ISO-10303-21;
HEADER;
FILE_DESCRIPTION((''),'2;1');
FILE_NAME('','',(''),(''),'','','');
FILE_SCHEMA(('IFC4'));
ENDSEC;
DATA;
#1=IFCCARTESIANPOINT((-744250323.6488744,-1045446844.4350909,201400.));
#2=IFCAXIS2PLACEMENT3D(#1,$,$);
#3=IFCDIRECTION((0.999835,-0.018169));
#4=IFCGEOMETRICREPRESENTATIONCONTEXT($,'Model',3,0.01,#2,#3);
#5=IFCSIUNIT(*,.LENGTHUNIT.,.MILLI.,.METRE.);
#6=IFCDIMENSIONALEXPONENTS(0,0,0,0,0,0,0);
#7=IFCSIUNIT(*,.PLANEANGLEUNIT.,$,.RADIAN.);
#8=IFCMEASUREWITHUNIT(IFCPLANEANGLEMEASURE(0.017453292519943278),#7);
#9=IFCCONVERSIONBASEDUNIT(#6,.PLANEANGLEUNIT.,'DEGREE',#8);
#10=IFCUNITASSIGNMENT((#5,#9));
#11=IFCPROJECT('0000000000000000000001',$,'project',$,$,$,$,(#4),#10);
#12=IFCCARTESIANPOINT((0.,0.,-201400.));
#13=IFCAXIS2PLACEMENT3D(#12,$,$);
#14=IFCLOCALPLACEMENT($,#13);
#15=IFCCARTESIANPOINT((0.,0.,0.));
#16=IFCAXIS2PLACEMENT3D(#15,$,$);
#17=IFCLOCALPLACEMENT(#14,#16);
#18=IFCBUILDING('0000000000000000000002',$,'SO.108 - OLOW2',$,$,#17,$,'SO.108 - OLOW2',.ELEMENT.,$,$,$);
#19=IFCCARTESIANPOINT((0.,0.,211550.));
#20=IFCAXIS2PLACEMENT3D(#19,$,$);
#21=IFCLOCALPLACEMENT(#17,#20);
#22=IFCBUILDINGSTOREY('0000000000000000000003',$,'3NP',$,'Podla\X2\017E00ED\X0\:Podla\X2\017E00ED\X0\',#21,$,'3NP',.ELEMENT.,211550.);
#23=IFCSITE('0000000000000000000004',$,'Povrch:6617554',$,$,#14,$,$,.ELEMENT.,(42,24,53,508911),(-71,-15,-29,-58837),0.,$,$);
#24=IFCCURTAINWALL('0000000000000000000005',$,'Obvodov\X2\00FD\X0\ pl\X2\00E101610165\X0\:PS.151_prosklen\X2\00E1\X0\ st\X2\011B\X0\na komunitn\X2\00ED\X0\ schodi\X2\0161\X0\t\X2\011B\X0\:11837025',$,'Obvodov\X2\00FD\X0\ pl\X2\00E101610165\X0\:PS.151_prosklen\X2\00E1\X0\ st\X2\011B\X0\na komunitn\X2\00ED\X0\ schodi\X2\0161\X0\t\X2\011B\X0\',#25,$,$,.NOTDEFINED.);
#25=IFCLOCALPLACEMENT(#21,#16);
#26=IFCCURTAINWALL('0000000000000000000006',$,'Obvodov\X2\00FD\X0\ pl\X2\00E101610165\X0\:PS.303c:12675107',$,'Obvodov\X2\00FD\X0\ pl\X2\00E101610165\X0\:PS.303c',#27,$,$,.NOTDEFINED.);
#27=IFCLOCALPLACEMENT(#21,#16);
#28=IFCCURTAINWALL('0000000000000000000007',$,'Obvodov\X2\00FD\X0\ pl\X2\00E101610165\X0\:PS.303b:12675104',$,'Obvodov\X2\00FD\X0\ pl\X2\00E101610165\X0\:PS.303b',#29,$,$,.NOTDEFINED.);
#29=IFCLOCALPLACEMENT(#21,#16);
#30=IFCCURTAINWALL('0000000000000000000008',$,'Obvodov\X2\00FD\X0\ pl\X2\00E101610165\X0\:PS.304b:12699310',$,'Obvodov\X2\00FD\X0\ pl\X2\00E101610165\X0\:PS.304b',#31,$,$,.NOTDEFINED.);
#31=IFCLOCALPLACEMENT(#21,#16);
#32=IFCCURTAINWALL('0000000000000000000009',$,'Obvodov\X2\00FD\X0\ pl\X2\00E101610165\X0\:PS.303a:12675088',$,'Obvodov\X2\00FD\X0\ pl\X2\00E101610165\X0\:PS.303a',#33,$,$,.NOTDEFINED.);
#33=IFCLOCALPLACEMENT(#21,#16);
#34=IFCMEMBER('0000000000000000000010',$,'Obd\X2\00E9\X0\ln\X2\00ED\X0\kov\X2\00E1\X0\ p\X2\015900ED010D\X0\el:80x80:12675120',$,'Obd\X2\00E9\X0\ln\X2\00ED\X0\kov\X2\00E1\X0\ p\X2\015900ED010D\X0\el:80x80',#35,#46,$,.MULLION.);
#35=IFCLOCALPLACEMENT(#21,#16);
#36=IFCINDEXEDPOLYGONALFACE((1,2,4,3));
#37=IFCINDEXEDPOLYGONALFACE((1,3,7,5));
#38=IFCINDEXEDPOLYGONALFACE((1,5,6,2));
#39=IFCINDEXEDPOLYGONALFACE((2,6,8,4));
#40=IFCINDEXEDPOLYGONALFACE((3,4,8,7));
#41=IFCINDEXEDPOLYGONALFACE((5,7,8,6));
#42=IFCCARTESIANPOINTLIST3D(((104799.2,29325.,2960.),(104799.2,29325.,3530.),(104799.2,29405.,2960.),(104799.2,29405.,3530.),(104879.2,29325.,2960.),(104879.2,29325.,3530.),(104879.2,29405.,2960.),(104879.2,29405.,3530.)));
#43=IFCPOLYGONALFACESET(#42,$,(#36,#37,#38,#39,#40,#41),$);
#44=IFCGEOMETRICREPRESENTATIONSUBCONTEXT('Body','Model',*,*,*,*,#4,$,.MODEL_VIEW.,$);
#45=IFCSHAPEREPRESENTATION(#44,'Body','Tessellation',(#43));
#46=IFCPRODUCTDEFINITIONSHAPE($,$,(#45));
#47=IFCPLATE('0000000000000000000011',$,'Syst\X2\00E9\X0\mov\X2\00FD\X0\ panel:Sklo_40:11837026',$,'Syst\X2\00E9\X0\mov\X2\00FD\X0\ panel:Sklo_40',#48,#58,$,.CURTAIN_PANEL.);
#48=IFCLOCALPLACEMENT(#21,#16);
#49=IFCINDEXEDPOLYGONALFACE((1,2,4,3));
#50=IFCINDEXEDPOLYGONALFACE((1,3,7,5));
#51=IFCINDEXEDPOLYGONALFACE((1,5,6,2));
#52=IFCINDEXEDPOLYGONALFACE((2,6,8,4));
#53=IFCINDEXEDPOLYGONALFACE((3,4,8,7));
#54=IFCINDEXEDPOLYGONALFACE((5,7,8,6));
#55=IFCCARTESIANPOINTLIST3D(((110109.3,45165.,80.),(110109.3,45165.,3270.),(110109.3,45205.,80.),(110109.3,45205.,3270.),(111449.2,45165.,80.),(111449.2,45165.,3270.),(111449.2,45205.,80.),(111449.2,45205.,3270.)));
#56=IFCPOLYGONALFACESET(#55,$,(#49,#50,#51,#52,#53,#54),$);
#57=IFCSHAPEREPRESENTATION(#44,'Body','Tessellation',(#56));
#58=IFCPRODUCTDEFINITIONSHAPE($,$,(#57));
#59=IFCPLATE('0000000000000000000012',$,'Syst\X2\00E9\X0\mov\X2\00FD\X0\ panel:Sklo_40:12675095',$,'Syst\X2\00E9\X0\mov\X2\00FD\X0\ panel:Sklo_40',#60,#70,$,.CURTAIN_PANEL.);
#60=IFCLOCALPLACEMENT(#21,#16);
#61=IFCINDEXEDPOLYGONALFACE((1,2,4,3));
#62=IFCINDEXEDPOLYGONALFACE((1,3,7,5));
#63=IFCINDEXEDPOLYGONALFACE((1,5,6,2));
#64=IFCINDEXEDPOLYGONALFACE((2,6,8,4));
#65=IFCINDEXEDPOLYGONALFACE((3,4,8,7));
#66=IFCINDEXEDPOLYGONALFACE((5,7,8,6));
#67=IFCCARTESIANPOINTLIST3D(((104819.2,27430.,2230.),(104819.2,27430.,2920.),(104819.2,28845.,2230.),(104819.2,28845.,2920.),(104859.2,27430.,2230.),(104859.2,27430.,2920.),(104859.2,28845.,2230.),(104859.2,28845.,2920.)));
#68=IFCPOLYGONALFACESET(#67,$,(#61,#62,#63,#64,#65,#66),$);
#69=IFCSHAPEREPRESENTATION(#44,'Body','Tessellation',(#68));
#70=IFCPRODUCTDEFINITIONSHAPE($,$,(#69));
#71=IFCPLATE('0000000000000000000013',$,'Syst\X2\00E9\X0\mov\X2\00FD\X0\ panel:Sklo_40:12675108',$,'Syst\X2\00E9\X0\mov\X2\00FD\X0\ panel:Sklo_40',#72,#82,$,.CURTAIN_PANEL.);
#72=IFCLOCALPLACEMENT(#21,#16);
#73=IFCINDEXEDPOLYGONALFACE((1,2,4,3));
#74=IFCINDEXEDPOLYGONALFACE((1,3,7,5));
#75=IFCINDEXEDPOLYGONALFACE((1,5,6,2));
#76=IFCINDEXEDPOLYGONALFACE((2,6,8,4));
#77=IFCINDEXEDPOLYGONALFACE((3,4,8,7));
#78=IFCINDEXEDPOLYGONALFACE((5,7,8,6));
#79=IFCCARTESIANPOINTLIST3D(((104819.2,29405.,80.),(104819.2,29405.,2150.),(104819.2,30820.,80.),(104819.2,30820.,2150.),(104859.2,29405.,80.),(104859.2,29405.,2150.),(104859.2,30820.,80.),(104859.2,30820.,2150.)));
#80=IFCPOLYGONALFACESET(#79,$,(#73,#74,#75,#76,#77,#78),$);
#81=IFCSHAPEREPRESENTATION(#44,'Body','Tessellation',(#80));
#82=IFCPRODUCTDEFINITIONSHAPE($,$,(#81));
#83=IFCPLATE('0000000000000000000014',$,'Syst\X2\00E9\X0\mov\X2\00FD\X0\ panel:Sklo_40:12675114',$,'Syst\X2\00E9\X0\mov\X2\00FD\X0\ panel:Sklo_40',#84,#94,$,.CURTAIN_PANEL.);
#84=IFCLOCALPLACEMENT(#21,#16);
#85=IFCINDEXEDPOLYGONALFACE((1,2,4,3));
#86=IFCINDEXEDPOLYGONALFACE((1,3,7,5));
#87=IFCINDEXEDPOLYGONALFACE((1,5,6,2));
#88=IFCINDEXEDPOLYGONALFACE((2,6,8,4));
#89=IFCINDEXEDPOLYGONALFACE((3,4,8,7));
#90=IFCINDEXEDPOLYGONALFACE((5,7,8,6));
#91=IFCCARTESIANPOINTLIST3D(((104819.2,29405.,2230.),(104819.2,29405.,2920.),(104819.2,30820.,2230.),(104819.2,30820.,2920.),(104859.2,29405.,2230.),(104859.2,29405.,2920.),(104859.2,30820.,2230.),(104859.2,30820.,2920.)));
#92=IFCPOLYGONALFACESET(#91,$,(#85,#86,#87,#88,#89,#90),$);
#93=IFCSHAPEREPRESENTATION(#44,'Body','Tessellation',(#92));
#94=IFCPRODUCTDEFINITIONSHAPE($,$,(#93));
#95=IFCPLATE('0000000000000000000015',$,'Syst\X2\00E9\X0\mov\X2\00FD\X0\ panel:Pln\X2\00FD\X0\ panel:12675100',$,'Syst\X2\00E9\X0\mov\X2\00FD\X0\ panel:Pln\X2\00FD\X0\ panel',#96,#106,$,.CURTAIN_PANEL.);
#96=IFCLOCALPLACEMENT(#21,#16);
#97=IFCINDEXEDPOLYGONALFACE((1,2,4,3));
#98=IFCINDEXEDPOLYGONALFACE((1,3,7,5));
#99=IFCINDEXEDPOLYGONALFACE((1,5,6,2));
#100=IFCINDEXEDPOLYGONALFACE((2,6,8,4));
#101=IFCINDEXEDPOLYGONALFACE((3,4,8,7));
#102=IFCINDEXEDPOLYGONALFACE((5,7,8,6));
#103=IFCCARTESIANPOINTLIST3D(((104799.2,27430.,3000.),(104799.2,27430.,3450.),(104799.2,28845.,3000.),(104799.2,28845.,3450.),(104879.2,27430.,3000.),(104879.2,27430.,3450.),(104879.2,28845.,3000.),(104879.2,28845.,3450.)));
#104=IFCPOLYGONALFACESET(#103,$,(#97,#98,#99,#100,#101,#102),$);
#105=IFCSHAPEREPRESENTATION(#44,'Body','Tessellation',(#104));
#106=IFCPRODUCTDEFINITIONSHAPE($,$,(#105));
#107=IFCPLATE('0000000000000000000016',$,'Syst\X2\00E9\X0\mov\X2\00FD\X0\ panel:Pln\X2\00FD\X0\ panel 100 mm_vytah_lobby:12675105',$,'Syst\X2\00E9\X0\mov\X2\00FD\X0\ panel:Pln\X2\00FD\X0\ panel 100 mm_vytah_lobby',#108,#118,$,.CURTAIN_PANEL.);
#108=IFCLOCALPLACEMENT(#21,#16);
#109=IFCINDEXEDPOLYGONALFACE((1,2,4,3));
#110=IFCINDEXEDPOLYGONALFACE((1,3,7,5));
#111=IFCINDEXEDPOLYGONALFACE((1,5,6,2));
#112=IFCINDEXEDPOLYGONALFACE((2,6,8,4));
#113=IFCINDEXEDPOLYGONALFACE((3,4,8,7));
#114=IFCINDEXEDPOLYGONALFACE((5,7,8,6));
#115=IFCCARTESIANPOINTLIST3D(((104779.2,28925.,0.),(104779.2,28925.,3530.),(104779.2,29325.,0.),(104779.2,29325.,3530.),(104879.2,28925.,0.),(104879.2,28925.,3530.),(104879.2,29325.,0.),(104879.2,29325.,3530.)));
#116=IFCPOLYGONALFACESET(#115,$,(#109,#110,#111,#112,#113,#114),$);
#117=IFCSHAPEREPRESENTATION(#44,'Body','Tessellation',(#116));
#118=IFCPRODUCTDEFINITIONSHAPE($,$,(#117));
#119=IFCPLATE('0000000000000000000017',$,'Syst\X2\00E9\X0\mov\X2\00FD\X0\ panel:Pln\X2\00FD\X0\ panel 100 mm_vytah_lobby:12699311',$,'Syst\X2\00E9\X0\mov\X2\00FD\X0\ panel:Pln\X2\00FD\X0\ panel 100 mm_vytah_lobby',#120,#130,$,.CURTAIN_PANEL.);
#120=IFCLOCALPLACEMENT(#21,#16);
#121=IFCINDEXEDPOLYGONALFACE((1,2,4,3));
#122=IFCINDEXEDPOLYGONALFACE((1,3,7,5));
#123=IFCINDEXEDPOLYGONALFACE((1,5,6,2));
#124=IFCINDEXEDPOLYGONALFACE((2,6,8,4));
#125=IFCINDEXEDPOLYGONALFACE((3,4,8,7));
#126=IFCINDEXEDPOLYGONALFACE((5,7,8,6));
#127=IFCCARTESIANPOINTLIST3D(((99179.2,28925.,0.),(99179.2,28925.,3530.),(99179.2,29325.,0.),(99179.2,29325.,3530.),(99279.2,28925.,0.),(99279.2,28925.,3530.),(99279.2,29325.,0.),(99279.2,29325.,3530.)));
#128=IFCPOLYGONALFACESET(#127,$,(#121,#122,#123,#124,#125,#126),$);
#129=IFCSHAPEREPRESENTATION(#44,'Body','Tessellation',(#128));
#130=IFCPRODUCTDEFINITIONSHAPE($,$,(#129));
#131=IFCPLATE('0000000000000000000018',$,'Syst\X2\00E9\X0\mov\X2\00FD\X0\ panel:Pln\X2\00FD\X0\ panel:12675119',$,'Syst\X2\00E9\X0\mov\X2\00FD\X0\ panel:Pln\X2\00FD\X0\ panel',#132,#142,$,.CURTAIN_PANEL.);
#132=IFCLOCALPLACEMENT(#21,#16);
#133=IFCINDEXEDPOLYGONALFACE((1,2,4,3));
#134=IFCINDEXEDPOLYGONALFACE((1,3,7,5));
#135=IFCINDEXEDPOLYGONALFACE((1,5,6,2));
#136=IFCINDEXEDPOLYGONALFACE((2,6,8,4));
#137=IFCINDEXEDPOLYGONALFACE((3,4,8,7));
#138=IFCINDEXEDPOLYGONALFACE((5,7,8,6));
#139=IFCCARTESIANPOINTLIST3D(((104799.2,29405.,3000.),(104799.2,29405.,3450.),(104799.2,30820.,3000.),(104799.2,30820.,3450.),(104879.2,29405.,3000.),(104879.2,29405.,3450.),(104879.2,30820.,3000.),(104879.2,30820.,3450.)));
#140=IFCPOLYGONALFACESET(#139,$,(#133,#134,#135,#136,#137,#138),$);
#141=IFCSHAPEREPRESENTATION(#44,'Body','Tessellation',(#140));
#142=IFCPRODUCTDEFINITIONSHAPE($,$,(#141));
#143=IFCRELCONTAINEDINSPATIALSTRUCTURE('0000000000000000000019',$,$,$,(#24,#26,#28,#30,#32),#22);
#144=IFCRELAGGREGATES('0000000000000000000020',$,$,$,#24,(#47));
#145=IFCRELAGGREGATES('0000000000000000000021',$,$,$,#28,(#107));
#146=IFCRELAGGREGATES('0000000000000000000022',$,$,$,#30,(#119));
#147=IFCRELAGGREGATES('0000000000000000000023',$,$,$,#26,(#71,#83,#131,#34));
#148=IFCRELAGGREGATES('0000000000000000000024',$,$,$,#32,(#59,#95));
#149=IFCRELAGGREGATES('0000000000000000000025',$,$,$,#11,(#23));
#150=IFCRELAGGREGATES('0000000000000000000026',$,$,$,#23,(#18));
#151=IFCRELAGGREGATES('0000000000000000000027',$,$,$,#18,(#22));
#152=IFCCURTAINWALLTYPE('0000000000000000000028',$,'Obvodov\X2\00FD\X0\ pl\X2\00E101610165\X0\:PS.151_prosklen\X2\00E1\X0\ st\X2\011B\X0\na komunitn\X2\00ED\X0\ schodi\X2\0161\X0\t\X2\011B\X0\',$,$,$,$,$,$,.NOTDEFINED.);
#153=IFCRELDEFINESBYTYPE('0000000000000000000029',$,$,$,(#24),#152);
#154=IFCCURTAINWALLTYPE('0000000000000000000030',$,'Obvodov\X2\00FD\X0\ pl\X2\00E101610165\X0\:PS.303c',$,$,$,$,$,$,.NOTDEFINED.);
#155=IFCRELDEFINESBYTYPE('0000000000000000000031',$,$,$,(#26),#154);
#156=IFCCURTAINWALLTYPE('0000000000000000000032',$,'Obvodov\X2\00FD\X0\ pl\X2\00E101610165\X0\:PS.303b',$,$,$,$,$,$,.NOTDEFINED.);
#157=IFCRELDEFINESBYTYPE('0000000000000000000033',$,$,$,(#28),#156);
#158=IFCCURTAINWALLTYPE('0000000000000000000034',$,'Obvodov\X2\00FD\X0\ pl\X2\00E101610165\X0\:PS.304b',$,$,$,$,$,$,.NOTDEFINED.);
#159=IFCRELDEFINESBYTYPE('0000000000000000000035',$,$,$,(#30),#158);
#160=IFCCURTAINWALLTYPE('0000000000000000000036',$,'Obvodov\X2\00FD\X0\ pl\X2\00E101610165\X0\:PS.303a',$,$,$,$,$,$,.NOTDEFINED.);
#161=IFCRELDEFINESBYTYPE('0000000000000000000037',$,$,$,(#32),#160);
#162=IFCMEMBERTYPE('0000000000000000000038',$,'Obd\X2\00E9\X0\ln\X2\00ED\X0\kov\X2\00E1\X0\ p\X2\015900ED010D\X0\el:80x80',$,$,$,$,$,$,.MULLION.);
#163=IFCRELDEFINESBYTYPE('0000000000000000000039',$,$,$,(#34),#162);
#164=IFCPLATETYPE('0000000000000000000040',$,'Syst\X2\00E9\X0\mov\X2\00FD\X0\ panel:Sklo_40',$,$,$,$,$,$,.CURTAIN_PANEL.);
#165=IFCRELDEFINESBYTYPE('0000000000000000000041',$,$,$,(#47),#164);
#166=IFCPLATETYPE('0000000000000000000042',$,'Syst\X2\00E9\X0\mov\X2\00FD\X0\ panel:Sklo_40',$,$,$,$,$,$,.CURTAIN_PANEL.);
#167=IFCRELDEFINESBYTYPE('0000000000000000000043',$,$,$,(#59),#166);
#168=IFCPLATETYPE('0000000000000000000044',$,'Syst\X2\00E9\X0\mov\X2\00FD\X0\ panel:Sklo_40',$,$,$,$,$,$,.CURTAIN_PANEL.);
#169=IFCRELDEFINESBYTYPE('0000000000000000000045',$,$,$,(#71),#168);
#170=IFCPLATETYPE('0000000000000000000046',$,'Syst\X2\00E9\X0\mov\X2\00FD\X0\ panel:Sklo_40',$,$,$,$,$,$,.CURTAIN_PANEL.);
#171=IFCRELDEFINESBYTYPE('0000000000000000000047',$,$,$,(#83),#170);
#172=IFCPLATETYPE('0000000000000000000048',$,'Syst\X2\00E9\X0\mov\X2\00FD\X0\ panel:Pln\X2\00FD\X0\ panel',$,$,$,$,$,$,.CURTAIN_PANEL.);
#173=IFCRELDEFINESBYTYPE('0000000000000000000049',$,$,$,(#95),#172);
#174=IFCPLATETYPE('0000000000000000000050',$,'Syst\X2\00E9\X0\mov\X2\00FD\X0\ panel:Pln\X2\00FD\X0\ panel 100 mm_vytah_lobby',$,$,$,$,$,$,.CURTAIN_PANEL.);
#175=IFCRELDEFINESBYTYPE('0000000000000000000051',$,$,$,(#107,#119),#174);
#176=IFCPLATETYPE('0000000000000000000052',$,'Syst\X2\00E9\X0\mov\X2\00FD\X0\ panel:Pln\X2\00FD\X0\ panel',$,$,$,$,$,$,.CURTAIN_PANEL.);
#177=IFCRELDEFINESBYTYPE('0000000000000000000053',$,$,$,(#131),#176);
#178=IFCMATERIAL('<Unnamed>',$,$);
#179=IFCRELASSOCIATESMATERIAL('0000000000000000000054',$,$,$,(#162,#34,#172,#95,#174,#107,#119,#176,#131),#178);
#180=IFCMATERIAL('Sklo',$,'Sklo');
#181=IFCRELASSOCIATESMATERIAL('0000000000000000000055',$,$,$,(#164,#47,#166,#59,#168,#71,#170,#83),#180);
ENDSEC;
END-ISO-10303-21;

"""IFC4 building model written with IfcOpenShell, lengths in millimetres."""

from ifc_helpers import new_model, entity, si_unit, converted_unit, direction, frame, origin, place, context, subcontext, project, spatial, indexed_curve, outline, extrude, source, transform, mapped, material, type_object, type_shapes, element, aggregate, save


model = new_model("IFC4")

# Units and contexts
model_context = context("Model", 3, precision=0.01, world=frame((-744250323.6488744, -1045446844.4350909, 201400.0)), true_north=direction((0.999835, -0.018169)))
body_context = subcontext(model_context, "Body", "Model", "MODEL_VIEW")
ifc_project = project(units=[si_unit("LENGTHUNIT", "METRE", prefix="MILLI"), converted_unit("PLANEANGLEUNIT", "DEGREE", entity("IfcPlaneAngleMeasure", 0.017453292519943278), si_unit("PLANEANGLEUNIT", "RADIAN"), dimensions=[0, 0, 0, 0, 0, 0, 0])], contexts=[model_context])

# Site, building, storey
site_placement = place(None, frame((0.0, 0.0, -201400.0)))
site = spatial("IfcSite", under=ifc_project, at=site_placement, Name="Povrch:6617554", CompositionType="ELEMENT", RefLatitude=(42, 24, 53, 508911), RefLongitude=(-71, -15, -29, -58837), RefElevation=0.0)
building_placement = place(site_placement, origin())
building = spatial("IfcBuilding", under=site, at=building_placement, Name="SO.108 - OLOW2", LongName="SO.108 - OLOW2", CompositionType="ELEMENT")
storey_placement = place(building_placement, frame((0.0, 0.0, 211550.0)))
storey = spatial("IfcBuildingStorey", under=building, at=storey_placement, Name="3NP", ObjectType="Podlaží:Podlaží", LongName="3NP", CompositionType="ELEMENT", Elevation=211550.0)

# Curtain wall
curtain_wall_type_1 = type_object("IfcCurtainWallType", Name="Obvodový plášť:PS.151_prosklená stěna komunitní schodiště", PredefinedType="NOTDEFINED")
curtain_wall_1_placement = place(storey_placement, frame((0.0, 0.0, -211550.0)))
curtain_wall_1 = element("IfcCurtainWall", 1, at=curtain_wall_1_placement, inside=storey, type_object=curtain_wall_type_1, Name="Obvodový plášť:PS.151_prosklená stěna komunitní schodiště:11837025", ObjectType="Obvodový plášť:PS.151_prosklená stěna komunitní schodiště", PredefinedType="NOTDEFINED")
ifc_material_1 = material(Name="<Unnamed>")

# Curtain wall
curtain_wall_type_2 = type_object("IfcCurtainWallType", Name="Obvodový plášť:PS.303c", PredefinedType="NOTDEFINED")
curtain_wall_2_placement = place(storey_placement, frame((0.0, 0.0, -211550.0)))
curtain_wall_2 = element("IfcCurtainWall", 2, at=curtain_wall_2_placement, inside=storey, type_object=curtain_wall_type_2, Name="Obvodový plášť:PS.303c:12675107", ObjectType="Obvodový plášť:PS.303c", PredefinedType="NOTDEFINED")

# Curtain walls
curtain_wall_type_3 = type_object("IfcCurtainWallType", Name="Obvodový plášť:PS.303b", PredefinedType="NOTDEFINED")
curtain_wall_3_placement = place(storey_placement, frame((0.0, 0.0, -211550.0)))
curtain_wall_3 = element("IfcCurtainWall", 3, at=curtain_wall_3_placement, inside=storey, type_object=curtain_wall_type_3, Name="Obvodový plášť:PS.303b:12675104", ObjectType="Obvodový plášť:PS.303b", PredefinedType="NOTDEFINED")
curtain_wall_type_4 = type_object("IfcCurtainWallType", Name="Obvodový plášť:PS.304b", PredefinedType="NOTDEFINED")
curtain_wall_4_placement = place(storey_placement, frame((0.0, 0.0, -211550.0)))
curtain_wall_4 = element("IfcCurtainWall", 4, at=curtain_wall_4_placement, inside=storey, type_object=curtain_wall_type_4, Name="Obvodový plášť:PS.304b:12699310", ObjectType="Obvodový plášť:PS.304b", PredefinedType="NOTDEFINED")

# Curtain wall
curtain_wall_type_5 = type_object("IfcCurtainWallType", Name="Obvodový plášť:PS.303a", PredefinedType="NOTDEFINED")
curtain_wall_5_placement = place(storey_placement, frame((0.0, 0.0, -211550.0)))
curtain_wall_5 = element("IfcCurtainWall", 5, at=curtain_wall_5_placement, inside=storey, type_object=curtain_wall_type_5, Name="Obvodový plášť:PS.303a:12675088", ObjectType="Obvodový plášť:PS.303a", PredefinedType="NOTDEFINED")

# Member
member_type_1 = type_object("IfcMemberType", Name="Obdélníková příčel:80x80", PredefinedType="MULLION", material=ifc_material_1)
shared_shape_1 = source(origin(), body_context, "Body", "SweptSolid", [
    extrude(outline(indexed_curve([(-40.0, -40.0), (40.0, -40.0), (40.0, 40.0), (-40.0, 40.0), (-40.0, -40.0)], self_intersect=False)), frame((-40.0, 0.0, -570.0), z_axis=(0.0, 0.0, 1.0), x_axis=(-1.0, 0.0, 0.0)), (0.0, 0.0, 1.0), 570.0),
])
type_shapes(member_type_1, [shared_shape_1])
member_1_placement = place(curtain_wall_2_placement, frame((104839.2, 29325.0, 214510.0), z_axis=(0.0, 0.0, -1.0), x_axis=(0.0, -1.0, 0.0)))
member_1 = element("IfcMember", 6, at=member_1_placement, type_object=member_type_1, material=ifc_material_1, Name="Obdélníková příčel:80x80:12675120", ObjectType="Obdélníková příčel:80x80", PredefinedType="MULLION", context=body_context, shape_type="MappedRepresentation", body=[
    mapped(shared_shape_1, transform((0.0, 0.0, 0.0), scale=1.0)),
])

# Plates
ifc_material_2 = material(Name="Sklo", Category="Sklo")
plate_type_1 = type_object("IfcPlateType", Name="Systémový panel:Sklo_40", PredefinedType="CURTAIN_PANEL", material=ifc_material_2)
shared_shape_2 = source(origin(), body_context, "Body", "SweptSolid", [
    extrude(outline(indexed_curve([(-20.0, -670.0), (20.0, -670.0), (20.0, 670.0), (-20.0, 670.0), (-20.0, -670.0)], self_intersect=False)), frame((0.0, 0.0, 0.0), z_axis=(0.0, 0.0, 1.0), x_axis=(0.0, 1.0, 0.0)), (0.0, 0.0, 1.0), 3190.0),
])
type_shapes(plate_type_1, [shared_shape_2])
plate_1_placement = place(curtain_wall_1_placement, frame((110779.3, 45185.0, 211630.0)))
plate_1 = element("IfcPlate", 7, at=plate_1_placement, type_object=plate_type_1, material=ifc_material_2, Name="Systémový panel:Sklo_40:11837026", ObjectType="Systémový panel:Sklo_40", PredefinedType="CURTAIN_PANEL", context=body_context, shape_type="MappedRepresentation", body=[
    mapped(shared_shape_2, transform((0.0, 0.0, 0.0), scale=1.0)),
])
aggregate(curtain_wall_1, [plate_1])
plate_type_2 = type_object("IfcPlateType", Name="Systémový panel:Sklo_40", PredefinedType="CURTAIN_PANEL", material=ifc_material_2)
shared_shape_3 = source(origin(), body_context, "Body", "SweptSolid", [
    extrude(outline(indexed_curve([(-20.0, -707.5), (20.0, -707.5), (20.0, 707.5), (-20.0, 707.5), (-20.0, -707.5)], self_intersect=False)), frame((0.0, 0.0, 0.0), z_axis=(0.0, 0.0, 1.0), x_axis=(0.0, 1.0, 0.0)), (0.0, 0.0, 1.0), 690.0),
])
type_shapes(plate_type_2, [shared_shape_3])
plate_2_placement = place(curtain_wall_5_placement, frame((104839.2, 28137.5, 213780.0), z_axis=(0.0, 0.0, 1.0), x_axis=(0.0, -1.0, 0.0)))
plate_2 = element("IfcPlate", 8, at=plate_2_placement, type_object=plate_type_2, material=ifc_material_2, Name="Systémový panel:Sklo_40:12675095", ObjectType="Systémový panel:Sklo_40", PredefinedType="CURTAIN_PANEL", context=body_context, shape_type="MappedRepresentation", body=[
    mapped(shared_shape_3, transform((0.0, 0.0, 0.0), scale=1.0)),
])
plate_type_3 = type_object("IfcPlateType", Name="Systémový panel:Sklo_40", PredefinedType="CURTAIN_PANEL", material=ifc_material_2)
shared_shape_4 = source(origin(), body_context, "Body", "SweptSolid", [
    extrude(outline(indexed_curve([(-20.0, -707.5), (20.0, -707.5), (20.0, 707.5), (-20.0, 707.5), (-20.0, -707.5)], self_intersect=False)), frame((0.0, 0.0, 0.0), z_axis=(0.0, 0.0, 1.0), x_axis=(0.0, 1.0, 0.0)), (0.0, 0.0, 1.0), 2070.0),
])
type_shapes(plate_type_3, [shared_shape_4])
plate_3_placement = place(curtain_wall_2_placement, frame((104839.2, 30112.5, 211630.0), z_axis=(0.0, 0.0, 1.0), x_axis=(0.0, -1.0, 0.0)))
plate_3 = element("IfcPlate", 9, at=plate_3_placement, type_object=plate_type_3, material=ifc_material_2, Name="Systémový panel:Sklo_40:12675108", ObjectType="Systémový panel:Sklo_40", PredefinedType="CURTAIN_PANEL", context=body_context, shape_type="MappedRepresentation", body=[
    mapped(shared_shape_4, transform((0.0, 0.0, 0.0), scale=1.0)),
])
plate_type_4 = type_object("IfcPlateType", Name="Systémový panel:Sklo_40", PredefinedType="CURTAIN_PANEL", material=ifc_material_2)
shared_shape_5 = source(origin(), body_context, "Body", "SweptSolid", [
    extrude(outline(indexed_curve([(-20.0, -707.5), (20.0, -707.5), (20.0, 707.5), (-20.0, 707.5), (-20.0, -707.5)], self_intersect=False)), frame((0.0, 0.0, 0.0), z_axis=(0.0, 0.0, 1.0), x_axis=(0.0, 1.0, 0.0)), (0.0, 0.0, 1.0), 690.0),
])
type_shapes(plate_type_4, [shared_shape_5])
plate_4_placement = place(curtain_wall_2_placement, frame((104839.2, 30112.5, 213780.0), z_axis=(0.0, 0.0, 1.0), x_axis=(0.0, -1.0, 0.0)))
plate_4 = element("IfcPlate", 10, at=plate_4_placement, type_object=plate_type_4, material=ifc_material_2, Name="Systémový panel:Sklo_40:12675114", ObjectType="Systémový panel:Sklo_40", PredefinedType="CURTAIN_PANEL", context=body_context, shape_type="MappedRepresentation", body=[
    mapped(shared_shape_5, transform((0.0, 0.0, 0.0), scale=1.0)),
])
plate_type_5 = type_object("IfcPlateType", Name="Systémový panel:Plný panel", PredefinedType="CURTAIN_PANEL", material=ifc_material_1)
shared_shape_6 = source(origin(), body_context, "Body", "SweptSolid", [
    extrude(outline(indexed_curve([(-40.0, -707.5), (40.0, -707.5), (40.0, 707.5), (-40.0, 707.5), (-40.0, -707.5)], self_intersect=False)), frame((0.0, 0.0, 0.0), z_axis=(0.0, 0.0, 1.0), x_axis=(0.0, 1.0, 0.0)), (0.0, 0.0, 1.0), 450.0),
])
type_shapes(plate_type_5, [shared_shape_6])
plate_5_placement = place(curtain_wall_5_placement, frame((104839.2, 28137.5, 214550.0), z_axis=(0.0, 0.0, 1.0), x_axis=(0.0, -1.0, 0.0)))
plate_5 = element("IfcPlate", 11, at=plate_5_placement, type_object=plate_type_5, material=ifc_material_1, Name="Systémový panel:Plný panel:12675100", ObjectType="Systémový panel:Plný panel", PredefinedType="CURTAIN_PANEL", context=body_context, shape_type="MappedRepresentation", body=[
    mapped(shared_shape_6, transform((0.0, 0.0, 0.0), scale=1.0)),
])
plate_type_6 = type_object("IfcPlateType", Name="Systémový panel:Plný panel 100 mm_vytah_lobby", PredefinedType="CURTAIN_PANEL", material=ifc_material_1)
shared_shape_7 = source(origin(), body_context, "Body", "SweptSolid", [
    extrude(outline(indexed_curve([(-50.0, -200.0), (50.0, -200.0), (50.0, 200.0), (-50.0, 200.0), (-50.0, -200.0)], self_intersect=False)), frame((0.0, 10.0, 0.0), z_axis=(0.0, 0.0, 1.0), x_axis=(0.0, 1.0, 0.0)), (0.0, 0.0, 1.0), 3530.0),
])
type_shapes(plate_type_6, [shared_shape_7])
plate_6_placement = place(curtain_wall_3_placement, frame((104839.2, 29125.0, 211550.0), z_axis=(0.0, 0.0, 1.0), x_axis=(0.0, 1.0, 0.0)))
plate_6 = element("IfcPlate", 12, at=plate_6_placement, type_object=plate_type_6, material=ifc_material_1, Name="Systémový panel:Plný panel 100 mm_vytah_lobby:12675105", ObjectType="Systémový panel:Plný panel 100 mm_vytah_lobby", PredefinedType="CURTAIN_PANEL", context=body_context, shape_type="MappedRepresentation", body=[
    mapped(shared_shape_7, transform((0.0, 0.0, 0.0), scale=1.0)),
])
aggregate(curtain_wall_3, [plate_6])
plate_7_placement = place(curtain_wall_4_placement, frame((99239.2, 29125.0, 211550.0), z_axis=(0.0, 0.0, 1.0), x_axis=(0.0, 1.0, 0.0)))
plate_7 = element("IfcPlate", 13, at=plate_7_placement, type_object=plate_type_6, material=ifc_material_1, Name="Systémový panel:Plný panel 100 mm_vytah_lobby:12699311", ObjectType="Systémový panel:Plný panel 100 mm_vytah_lobby", PredefinedType="CURTAIN_PANEL", context=body_context, shape_type="MappedRepresentation", body=[
    mapped(shared_shape_7, transform((0.0, 0.0, 0.0), scale=1.0)),
])
aggregate(curtain_wall_4, [plate_7])
plate_type_7 = type_object("IfcPlateType", Name="Systémový panel:Plný panel", PredefinedType="CURTAIN_PANEL", material=ifc_material_1)
shared_shape_8 = source(origin(), body_context, "Body", "SweptSolid", [
    extrude(outline(indexed_curve([(-40.0, -707.5), (40.0, -707.5), (40.0, 707.5), (-40.0, 707.5), (-40.0, -707.5)], self_intersect=False)), frame((0.0, 0.0, 0.0), z_axis=(0.0, 0.0, 1.0), x_axis=(0.0, 1.0, 0.0)), (0.0, 0.0, 1.0), 450.0),
])
type_shapes(plate_type_7, [shared_shape_8])
plate_8_placement = place(curtain_wall_2_placement, frame((104839.2, 30112.5, 214550.0), z_axis=(0.0, 0.0, 1.0), x_axis=(0.0, -1.0, 0.0)))
plate_8 = element("IfcPlate", 14, at=plate_8_placement, type_object=plate_type_7, material=ifc_material_1, Name="Systémový panel:Plný panel:12675119", ObjectType="Systémový panel:Plný panel", PredefinedType="CURTAIN_PANEL", context=body_context, shape_type="MappedRepresentation", body=[
    mapped(shared_shape_8, transform((0.0, 0.0, 0.0), scale=1.0)),
])
aggregate(curtain_wall_2, [plate_3, plate_4, plate_8, member_1])

aggregate(curtain_wall_5, [plate_2, plate_5])

save(model, "model.ifc")
